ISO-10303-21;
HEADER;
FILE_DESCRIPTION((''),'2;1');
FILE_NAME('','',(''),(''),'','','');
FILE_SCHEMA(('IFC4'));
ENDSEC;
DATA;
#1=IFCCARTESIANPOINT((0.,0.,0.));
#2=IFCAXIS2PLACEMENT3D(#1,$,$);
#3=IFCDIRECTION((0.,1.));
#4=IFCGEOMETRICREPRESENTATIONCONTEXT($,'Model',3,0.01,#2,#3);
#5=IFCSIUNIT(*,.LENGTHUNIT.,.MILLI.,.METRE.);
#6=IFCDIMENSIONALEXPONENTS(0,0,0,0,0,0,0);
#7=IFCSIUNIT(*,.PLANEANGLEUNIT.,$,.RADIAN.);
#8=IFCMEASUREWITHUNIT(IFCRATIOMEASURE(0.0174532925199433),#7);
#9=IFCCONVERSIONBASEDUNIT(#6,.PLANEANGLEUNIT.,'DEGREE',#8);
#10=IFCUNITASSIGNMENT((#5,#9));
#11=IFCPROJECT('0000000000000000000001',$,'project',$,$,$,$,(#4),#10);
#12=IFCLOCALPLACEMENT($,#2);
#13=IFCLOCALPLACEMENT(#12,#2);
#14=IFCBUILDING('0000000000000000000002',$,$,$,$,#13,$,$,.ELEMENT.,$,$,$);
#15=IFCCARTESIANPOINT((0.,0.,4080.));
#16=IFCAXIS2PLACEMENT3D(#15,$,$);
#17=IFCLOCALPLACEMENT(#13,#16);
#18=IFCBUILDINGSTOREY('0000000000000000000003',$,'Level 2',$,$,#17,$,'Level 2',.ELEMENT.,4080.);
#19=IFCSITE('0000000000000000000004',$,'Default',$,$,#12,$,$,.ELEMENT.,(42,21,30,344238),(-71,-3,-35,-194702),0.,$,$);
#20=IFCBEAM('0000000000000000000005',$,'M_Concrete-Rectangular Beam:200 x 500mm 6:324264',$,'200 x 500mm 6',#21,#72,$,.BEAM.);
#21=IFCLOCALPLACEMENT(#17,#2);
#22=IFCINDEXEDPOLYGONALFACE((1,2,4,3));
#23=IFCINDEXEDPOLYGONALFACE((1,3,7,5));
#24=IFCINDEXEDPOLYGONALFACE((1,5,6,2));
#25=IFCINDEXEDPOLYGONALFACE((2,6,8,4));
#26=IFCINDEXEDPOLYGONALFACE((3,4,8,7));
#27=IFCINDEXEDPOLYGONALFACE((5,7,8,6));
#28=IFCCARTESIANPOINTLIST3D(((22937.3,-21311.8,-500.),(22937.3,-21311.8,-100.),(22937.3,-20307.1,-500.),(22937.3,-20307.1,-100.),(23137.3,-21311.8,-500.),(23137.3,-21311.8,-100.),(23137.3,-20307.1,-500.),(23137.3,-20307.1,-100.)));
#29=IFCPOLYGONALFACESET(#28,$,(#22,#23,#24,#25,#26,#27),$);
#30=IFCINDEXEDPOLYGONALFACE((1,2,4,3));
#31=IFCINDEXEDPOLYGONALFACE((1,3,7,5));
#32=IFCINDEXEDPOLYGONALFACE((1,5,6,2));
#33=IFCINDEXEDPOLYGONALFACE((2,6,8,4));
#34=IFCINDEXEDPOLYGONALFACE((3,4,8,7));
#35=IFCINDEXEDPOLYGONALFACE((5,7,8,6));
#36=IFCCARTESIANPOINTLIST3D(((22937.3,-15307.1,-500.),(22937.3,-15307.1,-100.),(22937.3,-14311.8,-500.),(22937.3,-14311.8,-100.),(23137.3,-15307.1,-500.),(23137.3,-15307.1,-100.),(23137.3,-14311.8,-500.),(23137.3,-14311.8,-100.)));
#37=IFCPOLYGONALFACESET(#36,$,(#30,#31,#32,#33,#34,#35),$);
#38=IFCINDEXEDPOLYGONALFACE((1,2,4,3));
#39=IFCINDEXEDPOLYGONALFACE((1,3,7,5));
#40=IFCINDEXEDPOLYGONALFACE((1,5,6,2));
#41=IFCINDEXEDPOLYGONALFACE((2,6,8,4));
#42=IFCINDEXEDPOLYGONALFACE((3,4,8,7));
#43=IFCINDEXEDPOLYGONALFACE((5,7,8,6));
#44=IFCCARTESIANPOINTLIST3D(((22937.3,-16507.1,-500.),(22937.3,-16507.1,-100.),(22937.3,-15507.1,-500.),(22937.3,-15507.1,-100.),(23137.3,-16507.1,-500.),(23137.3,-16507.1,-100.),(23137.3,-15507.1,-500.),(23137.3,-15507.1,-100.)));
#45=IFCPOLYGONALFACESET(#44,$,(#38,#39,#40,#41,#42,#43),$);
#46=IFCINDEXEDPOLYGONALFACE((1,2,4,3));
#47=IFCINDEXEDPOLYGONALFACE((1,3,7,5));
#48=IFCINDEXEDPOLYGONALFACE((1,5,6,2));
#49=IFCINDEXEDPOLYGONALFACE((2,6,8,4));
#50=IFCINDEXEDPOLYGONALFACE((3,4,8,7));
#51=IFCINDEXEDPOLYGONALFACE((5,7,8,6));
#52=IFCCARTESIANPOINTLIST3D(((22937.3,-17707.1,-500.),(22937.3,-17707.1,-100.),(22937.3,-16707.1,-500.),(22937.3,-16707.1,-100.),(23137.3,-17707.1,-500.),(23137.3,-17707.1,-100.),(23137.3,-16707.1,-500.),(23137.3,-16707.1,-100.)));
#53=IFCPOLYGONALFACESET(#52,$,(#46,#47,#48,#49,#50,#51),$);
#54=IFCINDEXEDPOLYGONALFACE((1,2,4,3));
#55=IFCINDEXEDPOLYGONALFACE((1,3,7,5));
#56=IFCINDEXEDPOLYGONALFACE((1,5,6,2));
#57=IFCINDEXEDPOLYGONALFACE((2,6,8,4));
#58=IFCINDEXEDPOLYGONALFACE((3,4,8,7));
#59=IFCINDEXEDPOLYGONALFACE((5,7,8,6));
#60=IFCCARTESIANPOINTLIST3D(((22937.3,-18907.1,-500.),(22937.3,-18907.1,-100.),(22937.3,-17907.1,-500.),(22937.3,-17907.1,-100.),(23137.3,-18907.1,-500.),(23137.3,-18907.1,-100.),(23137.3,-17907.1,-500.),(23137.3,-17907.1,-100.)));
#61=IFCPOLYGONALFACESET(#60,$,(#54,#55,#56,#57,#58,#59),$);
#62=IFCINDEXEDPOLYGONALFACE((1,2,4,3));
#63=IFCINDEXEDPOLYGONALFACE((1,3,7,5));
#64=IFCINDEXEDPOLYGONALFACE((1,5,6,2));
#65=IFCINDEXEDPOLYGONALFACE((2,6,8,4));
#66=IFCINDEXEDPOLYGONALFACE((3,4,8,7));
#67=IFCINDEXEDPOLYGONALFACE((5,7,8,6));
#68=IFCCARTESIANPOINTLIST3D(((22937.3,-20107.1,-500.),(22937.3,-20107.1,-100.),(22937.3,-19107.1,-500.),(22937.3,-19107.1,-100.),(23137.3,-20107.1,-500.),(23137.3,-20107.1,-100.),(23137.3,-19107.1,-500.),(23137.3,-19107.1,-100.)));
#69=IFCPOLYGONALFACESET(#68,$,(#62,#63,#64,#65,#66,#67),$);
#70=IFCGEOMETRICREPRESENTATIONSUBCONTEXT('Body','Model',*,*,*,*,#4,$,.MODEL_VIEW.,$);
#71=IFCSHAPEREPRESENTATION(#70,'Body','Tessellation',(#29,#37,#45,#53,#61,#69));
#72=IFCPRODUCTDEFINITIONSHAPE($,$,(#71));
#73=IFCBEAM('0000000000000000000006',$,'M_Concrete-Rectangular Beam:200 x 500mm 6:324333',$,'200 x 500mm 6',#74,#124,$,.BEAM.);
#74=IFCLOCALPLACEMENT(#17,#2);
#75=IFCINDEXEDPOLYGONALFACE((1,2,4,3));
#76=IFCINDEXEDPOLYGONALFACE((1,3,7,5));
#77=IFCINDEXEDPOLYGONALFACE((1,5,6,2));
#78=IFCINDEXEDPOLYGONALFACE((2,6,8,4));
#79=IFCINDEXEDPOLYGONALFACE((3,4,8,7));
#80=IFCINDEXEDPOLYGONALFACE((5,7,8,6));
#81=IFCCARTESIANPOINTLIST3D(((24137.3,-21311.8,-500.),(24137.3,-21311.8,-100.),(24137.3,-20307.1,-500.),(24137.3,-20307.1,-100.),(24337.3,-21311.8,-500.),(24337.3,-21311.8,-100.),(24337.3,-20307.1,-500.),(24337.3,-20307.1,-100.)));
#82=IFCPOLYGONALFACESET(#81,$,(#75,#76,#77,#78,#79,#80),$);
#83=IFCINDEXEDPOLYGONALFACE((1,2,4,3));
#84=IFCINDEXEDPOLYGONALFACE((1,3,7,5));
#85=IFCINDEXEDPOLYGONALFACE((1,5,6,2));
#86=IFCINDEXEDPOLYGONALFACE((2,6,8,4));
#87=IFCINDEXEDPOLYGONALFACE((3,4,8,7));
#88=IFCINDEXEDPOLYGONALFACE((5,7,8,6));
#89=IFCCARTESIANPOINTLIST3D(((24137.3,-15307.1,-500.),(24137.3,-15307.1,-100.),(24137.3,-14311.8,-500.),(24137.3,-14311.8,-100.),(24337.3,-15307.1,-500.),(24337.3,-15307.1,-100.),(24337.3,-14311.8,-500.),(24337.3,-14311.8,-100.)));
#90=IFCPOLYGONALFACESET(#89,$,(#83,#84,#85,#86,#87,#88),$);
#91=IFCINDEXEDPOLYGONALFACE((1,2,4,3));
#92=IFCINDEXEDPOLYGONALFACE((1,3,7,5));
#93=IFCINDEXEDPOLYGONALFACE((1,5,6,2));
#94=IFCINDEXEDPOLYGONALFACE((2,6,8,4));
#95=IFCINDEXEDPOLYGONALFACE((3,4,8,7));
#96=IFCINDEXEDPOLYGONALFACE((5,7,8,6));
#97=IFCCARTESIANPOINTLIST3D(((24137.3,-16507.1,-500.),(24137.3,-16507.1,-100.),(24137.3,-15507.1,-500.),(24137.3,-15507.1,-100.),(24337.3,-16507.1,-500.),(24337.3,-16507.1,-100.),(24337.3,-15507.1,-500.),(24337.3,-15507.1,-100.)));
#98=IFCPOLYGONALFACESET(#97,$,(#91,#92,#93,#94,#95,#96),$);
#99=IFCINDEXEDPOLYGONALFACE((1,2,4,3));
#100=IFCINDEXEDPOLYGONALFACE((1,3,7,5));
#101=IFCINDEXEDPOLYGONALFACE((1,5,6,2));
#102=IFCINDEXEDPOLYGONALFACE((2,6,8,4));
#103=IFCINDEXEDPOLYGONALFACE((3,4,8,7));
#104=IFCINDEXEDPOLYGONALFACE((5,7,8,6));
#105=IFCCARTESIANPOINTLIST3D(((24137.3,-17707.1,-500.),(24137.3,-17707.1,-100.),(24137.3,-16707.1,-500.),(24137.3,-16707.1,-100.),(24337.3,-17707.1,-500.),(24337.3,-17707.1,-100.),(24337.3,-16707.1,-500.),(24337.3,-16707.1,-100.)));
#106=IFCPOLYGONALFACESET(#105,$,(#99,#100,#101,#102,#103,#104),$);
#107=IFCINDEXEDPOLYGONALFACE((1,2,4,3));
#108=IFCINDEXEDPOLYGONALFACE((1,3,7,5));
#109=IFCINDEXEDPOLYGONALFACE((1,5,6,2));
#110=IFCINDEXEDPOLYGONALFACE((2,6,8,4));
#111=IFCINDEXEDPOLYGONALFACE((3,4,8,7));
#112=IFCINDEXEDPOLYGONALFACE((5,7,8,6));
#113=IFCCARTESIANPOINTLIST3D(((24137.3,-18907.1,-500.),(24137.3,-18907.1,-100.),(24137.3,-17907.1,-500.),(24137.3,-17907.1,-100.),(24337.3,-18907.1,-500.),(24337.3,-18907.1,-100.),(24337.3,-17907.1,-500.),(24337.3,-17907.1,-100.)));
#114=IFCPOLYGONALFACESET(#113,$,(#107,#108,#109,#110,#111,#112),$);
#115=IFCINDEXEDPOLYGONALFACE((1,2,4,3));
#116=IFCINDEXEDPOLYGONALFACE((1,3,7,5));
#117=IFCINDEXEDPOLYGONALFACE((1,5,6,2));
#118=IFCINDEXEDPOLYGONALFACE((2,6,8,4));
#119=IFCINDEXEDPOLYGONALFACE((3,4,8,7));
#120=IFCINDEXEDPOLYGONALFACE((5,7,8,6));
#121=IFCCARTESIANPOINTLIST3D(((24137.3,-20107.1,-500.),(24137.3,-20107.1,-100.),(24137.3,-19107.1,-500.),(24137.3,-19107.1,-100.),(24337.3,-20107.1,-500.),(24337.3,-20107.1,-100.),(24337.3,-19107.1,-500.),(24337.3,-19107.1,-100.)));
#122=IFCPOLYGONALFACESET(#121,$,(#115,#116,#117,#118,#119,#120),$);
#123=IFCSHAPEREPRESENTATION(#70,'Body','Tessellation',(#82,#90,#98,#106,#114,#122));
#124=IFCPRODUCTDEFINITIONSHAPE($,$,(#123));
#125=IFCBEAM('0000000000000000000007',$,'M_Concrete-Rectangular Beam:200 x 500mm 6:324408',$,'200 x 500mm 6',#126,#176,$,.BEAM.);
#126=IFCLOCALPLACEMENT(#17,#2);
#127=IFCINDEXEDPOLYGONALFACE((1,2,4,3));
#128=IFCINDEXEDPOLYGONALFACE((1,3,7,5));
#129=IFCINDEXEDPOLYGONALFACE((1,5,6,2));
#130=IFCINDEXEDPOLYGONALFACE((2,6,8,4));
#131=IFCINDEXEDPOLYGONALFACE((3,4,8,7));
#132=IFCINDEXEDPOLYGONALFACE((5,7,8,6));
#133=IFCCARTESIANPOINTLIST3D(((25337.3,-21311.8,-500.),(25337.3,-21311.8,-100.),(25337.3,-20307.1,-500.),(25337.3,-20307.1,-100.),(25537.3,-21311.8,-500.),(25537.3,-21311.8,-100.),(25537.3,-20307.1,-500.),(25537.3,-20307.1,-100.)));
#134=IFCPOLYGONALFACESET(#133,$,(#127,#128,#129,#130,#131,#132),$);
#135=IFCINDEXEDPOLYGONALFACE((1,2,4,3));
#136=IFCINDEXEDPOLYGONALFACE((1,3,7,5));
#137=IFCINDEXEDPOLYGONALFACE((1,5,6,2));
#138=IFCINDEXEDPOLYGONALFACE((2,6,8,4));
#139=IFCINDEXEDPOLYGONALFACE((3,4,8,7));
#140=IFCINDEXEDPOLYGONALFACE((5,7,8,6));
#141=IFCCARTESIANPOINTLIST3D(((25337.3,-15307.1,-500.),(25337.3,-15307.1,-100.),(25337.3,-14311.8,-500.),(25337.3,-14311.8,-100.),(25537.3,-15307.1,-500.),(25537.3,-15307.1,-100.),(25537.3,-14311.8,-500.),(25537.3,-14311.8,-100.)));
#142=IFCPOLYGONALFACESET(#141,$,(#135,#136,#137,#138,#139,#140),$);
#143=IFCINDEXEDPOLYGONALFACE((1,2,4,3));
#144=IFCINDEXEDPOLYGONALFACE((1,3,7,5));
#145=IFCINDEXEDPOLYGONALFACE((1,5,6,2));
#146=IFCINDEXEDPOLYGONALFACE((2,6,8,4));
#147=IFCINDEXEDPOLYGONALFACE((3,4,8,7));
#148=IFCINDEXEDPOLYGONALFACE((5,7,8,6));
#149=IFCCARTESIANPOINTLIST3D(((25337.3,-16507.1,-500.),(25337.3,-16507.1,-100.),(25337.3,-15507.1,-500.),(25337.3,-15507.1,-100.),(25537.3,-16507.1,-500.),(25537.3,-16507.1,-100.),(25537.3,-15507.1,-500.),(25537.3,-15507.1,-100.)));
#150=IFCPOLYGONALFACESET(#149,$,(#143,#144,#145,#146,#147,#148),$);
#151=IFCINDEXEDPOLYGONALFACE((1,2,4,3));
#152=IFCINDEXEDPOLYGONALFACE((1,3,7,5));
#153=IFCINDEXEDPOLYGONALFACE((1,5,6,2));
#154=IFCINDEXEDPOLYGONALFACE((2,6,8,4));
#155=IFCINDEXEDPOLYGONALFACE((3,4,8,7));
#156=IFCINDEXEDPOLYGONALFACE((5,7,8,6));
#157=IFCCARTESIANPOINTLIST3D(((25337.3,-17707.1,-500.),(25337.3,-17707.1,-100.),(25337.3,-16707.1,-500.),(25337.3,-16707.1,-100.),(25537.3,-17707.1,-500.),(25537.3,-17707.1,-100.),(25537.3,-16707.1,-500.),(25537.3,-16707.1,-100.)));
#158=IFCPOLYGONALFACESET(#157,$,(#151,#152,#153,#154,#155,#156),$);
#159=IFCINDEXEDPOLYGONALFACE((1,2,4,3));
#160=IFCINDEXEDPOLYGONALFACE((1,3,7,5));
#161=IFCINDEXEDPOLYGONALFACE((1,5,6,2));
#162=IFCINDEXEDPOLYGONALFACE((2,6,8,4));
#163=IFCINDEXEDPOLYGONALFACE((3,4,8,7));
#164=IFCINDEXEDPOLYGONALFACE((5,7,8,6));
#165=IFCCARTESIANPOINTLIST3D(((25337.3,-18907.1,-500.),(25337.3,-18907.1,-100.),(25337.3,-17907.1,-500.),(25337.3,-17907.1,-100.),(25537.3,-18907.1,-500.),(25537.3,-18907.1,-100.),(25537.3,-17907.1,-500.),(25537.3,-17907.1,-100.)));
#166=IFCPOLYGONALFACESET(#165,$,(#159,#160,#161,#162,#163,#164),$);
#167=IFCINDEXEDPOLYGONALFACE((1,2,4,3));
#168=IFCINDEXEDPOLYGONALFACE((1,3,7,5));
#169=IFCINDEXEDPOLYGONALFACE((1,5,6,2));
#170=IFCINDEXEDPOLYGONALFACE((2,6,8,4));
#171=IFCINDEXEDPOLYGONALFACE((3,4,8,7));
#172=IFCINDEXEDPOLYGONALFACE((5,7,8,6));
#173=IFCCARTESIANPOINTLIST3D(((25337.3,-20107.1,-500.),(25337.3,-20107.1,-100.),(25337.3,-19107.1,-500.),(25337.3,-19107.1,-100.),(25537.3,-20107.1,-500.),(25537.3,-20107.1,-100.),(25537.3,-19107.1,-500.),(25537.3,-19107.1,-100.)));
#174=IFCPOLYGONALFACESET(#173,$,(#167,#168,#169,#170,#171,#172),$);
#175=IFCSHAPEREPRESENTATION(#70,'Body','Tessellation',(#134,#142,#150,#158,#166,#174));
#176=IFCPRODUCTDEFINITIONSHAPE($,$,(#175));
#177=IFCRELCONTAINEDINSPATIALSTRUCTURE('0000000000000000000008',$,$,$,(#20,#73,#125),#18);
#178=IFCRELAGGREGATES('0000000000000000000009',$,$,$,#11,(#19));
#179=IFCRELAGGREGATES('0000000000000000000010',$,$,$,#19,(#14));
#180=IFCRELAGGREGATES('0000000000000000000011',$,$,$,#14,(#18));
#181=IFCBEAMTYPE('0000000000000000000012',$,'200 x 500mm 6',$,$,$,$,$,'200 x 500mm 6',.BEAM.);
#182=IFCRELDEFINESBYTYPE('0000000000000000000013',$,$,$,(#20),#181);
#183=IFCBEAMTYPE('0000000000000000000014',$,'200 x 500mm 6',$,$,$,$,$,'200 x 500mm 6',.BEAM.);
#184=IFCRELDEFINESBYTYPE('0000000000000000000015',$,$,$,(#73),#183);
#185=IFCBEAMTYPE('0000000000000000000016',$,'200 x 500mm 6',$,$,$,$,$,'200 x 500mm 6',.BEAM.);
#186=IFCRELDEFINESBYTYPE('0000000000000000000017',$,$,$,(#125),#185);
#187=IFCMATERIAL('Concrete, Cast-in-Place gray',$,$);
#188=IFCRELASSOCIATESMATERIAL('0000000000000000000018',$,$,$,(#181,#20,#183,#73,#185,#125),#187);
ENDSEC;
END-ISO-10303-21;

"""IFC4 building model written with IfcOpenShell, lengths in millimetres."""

from ifc_helpers import new_model, entity, si_unit, converted_unit, direction, frame, frame_2d, origin, origin_2d_with_axis, place, context, subcontext, project, spatial, rectangle, extrude, source, transform, mapped, material, type_object, type_shapes, element, save


model = new_model("IFC4")

# Units and contexts
model_context = context("Model", 3, precision=0.01, world=origin(), true_north=direction((0.0, 1.0)))
body_context = subcontext(model_context, "Body", "Model", "MODEL_VIEW")
ifc_project = project(units=[si_unit("LENGTHUNIT", "METRE", prefix="MILLI"), converted_unit("PLANEANGLEUNIT", "DEGREE", entity("IfcRatioMeasure", 0.0174532925199433), si_unit("PLANEANGLEUNIT", "RADIAN"), dimensions=[0, 0, 0, 0, 0, 0, 0])], contexts=[model_context])

# Site, building, storey
site_placement = place(None, origin())
site = spatial("IfcSite", under=ifc_project, at=site_placement, Name="Default", CompositionType="ELEMENT", RefLatitude=(42, 21, 30, 344238), RefLongitude=(-71, -3, -35, -194702), RefElevation=0.0)
building_placement = place(site_placement, origin())
building = spatial("IfcBuilding", under=site, at=building_placement, CompositionType="ELEMENT")
storey_placement = place(building_placement, frame((0.0, 0.0, 4080.0)))
storey = spatial("IfcBuildingStorey", under=building, at=storey_placement, Name="Level 2", LongName="Level 2", CompositionType="ELEMENT", Elevation=4080.0)

# Beams
ifc_material = material(Name="Concrete, Cast-in-Place gray")
beam_type_1 = type_object("IfcBeamType", Name="200 x 500mm 6", ElementType="200 x 500mm 6", PredefinedType="BEAM", material=ifc_material)
shared_shape_1 = source(origin(), body_context, "Body", "SweptSolid", [
    extrude(rectangle(XDim=1004.7, YDim=200.0, at=frame_2d((0.0, 0.0), x_axis=(1.0, 0.0))), frame((23037.3, -20809.5, 3580.0), z_axis=(0.0, 0.0, 1.0), x_axis=(0.0, 1.0, 0.0)), (0.0, 0.0, 1.0), 400.0),
    extrude(rectangle(XDim=995.3, YDim=200.0, at=frame_2d((0.0, 0.0), x_axis=(1.0, 0.0))), frame((23037.3, -14809.5, 3580.0), z_axis=(0.0, 0.0, 1.0), x_axis=(0.0, -1.0, 0.0)), (0.0, 0.0, 1.0), 400.0),
    extrude(rectangle(XDim=1000.0, YDim=200.0, at=frame_2d((0.0, 0.0), x_axis=(1.0, 0.0))), frame((23037.3, -16007.1, 3580.0), z_axis=(0.0, 0.0, 1.0), x_axis=(0.0, -1.0, 0.0)), (0.0, 0.0, 1.0), 400.0),
    extrude(rectangle(XDim=1000.0, YDim=200.0, at=frame_2d((0.0, 0.0), x_axis=(1.0, 0.0))), frame((23037.3, -17207.1, 3580.0), z_axis=(0.0, 0.0, 1.0), x_axis=(0.0, -1.0, 0.0)), (0.0, 0.0, 1.0), 400.0),
    extrude(rectangle(XDim=1000.0, YDim=200.0, at=frame_2d((0.0, 0.0), x_axis=(1.0, 0.0))), frame((23037.3, -18407.1, 3580.0), z_axis=(0.0, 0.0, 1.0), x_axis=(0.0, -1.0, 0.0)), (0.0, 0.0, 1.0), 400.0),
    extrude(rectangle(XDim=1000.0, YDim=200.0, at=origin_2d_with_axis()), frame((23037.3, -19607.1, 3580.0), z_axis=(0.0, 0.0, 1.0), x_axis=(0.0, -1.0, 0.0)), (0.0, 0.0, 1.0), 400.0),
])
type_shapes(beam_type_1, [shared_shape_1])
beam_1_placement = place(storey_placement, frame((0.0, 0.0, -4080.0)))
element("IfcBeam", 1, at=beam_1_placement, inside=storey, type_object=beam_type_1, material=ifc_material, Name="M_Concrete-Rectangular Beam:200 x 500mm 6:324264", ObjectType="200 x 500mm 6", PredefinedType="BEAM", context=body_context, shape_type="MappedRepresentation", body=[
    mapped(shared_shape_1, transform((0.0, 0.0, 0.0), scale=1.0)),
])
beam_type_2 = type_object("IfcBeamType", Name="200 x 500mm 6", ElementType="200 x 500mm 6", PredefinedType="BEAM", material=ifc_material)
shared_shape_2 = source(origin(), body_context, "Body", "SweptSolid", [
    extrude(rectangle(XDim=1004.7, YDim=200.0, at=frame_2d((0.0, 0.0), x_axis=(1.0, 0.0))), frame((24237.3, -20809.5, 3580.0), z_axis=(0.0, 0.0, 1.0), x_axis=(0.0, 1.0, 0.0)), (0.0, 0.0, 1.0), 400.0),
    extrude(rectangle(XDim=995.3, YDim=200.0, at=frame_2d((0.0, 0.0), x_axis=(1.0, 0.0))), frame((24237.3, -14809.5, 3580.0), z_axis=(0.0, 0.0, 1.0), x_axis=(0.0, -1.0, 0.0)), (0.0, 0.0, 1.0), 400.0),
    extrude(rectangle(XDim=1000.0, YDim=200.0, at=frame_2d((0.0, 0.0), x_axis=(1.0, 0.0))), frame((24237.3, -16007.1, 3580.0), z_axis=(0.0, 0.0, 1.0), x_axis=(0.0, -1.0, 0.0)), (0.0, 0.0, 1.0), 400.0),
    extrude(rectangle(XDim=1000.0, YDim=200.0, at=origin_2d_with_axis()), frame((24237.3, -17207.1, 3580.0), z_axis=(0.0, 0.0, 1.0), x_axis=(0.0, -1.0, 0.0)), (0.0, 0.0, 1.0), 400.0),
    extrude(rectangle(XDim=1000.0, YDim=200.0, at=frame_2d((0.0, 0.0), x_axis=(1.0, 0.0))), frame((24237.3, -18407.1, 3580.0), z_axis=(0.0, 0.0, 1.0), x_axis=(0.0, -1.0, 0.0)), (0.0, 0.0, 1.0), 400.0),
    extrude(rectangle(XDim=1000.0, YDim=200.0, at=frame_2d((0.0, 0.0), x_axis=(1.0, 0.0))), frame((24237.3, -19607.1, 3580.0), z_axis=(0.0, 0.0, 1.0), x_axis=(0.0, -1.0, 0.0)), (0.0, 0.0, 1.0), 400.0),
])
type_shapes(beam_type_2, [shared_shape_2])
beam_2_placement = place(storey_placement, frame((0.0, 0.0, -4080.0)))
element("IfcBeam", 2, at=beam_2_placement, inside=storey, type_object=beam_type_2, material=ifc_material, Name="M_Concrete-Rectangular Beam:200 x 500mm 6:324333", ObjectType="200 x 500mm 6", PredefinedType="BEAM", context=body_context, shape_type="MappedRepresentation", body=[
    mapped(shared_shape_2, transform((0.0, 0.0, 0.0), scale=1.0)),
])
beam_type_3 = type_object("IfcBeamType", Name="200 x 500mm 6", ElementType="200 x 500mm 6", PredefinedType="BEAM", material=ifc_material)
shared_shape_3 = source(origin(), body_context, "Body", "SweptSolid", [
    extrude(rectangle(XDim=1004.7, YDim=200.0, at=frame_2d((0.0, 0.0), x_axis=(1.0, 0.0))), frame((25437.3, -20809.5, 3580.0), z_axis=(0.0, 0.0, 1.0), x_axis=(0.0, 1.0, 0.0)), (0.0, 0.0, 1.0), 400.0),
    extrude(rectangle(XDim=995.3, YDim=200.0, at=frame_2d((0.0, 0.0), x_axis=(1.0, 0.0))), frame((25437.3, -14809.5, 3580.0), z_axis=(0.0, 0.0, 1.0), x_axis=(0.0, -1.0, 0.0)), (0.0, 0.0, 1.0), 400.0),
    extrude(rectangle(XDim=1000.0, YDim=200.0, at=frame_2d((0.0, 0.0), x_axis=(1.0, 0.0))), frame((25437.3, -16007.1, 3580.0), z_axis=(0.0, 0.0, 1.0), x_axis=(0.0, -1.0, 0.0)), (0.0, 0.0, 1.0), 400.0),
    extrude(rectangle(XDim=1000.0, YDim=200.0, at=frame_2d((0.0, 0.0), x_axis=(1.0, 0.0))), frame((25437.3, -17207.1, 3580.0), z_axis=(0.0, 0.0, 1.0), x_axis=(0.0, -1.0, 0.0)), (0.0, 0.0, 1.0), 400.0),
    extrude(rectangle(XDim=1000.0, YDim=200.0, at=frame_2d((0.0, 0.0), x_axis=(1.0, 0.0))), frame((25437.3, -18407.1, 3580.0), z_axis=(0.0, 0.0, 1.0), x_axis=(0.0, -1.0, 0.0)), (0.0, 0.0, 1.0), 400.0),
    extrude(rectangle(XDim=1000.0, YDim=200.0, at=frame_2d((0.0, 0.0), x_axis=(1.0, 0.0))), frame((25437.3, -19607.1, 3580.0), z_axis=(0.0, 0.0, 1.0), x_axis=(0.0, -1.0, 0.0)), (0.0, 0.0, 1.0), 400.0),
])
type_shapes(beam_type_3, [shared_shape_3])
beam_3_placement = place(storey_placement, frame((0.0, 0.0, -4080.0)))
element("IfcBeam", 3, at=beam_3_placement, inside=storey, type_object=beam_type_3, material=ifc_material, Name="M_Concrete-Rectangular Beam:200 x 500mm 6:324408", ObjectType="200 x 500mm 6", PredefinedType="BEAM", context=body_context, shape_type="MappedRepresentation", body=[
    mapped(shared_shape_3, transform((0.0, 0.0, 0.0), scale=1.0)),
])

save(model, "model.ifc")
